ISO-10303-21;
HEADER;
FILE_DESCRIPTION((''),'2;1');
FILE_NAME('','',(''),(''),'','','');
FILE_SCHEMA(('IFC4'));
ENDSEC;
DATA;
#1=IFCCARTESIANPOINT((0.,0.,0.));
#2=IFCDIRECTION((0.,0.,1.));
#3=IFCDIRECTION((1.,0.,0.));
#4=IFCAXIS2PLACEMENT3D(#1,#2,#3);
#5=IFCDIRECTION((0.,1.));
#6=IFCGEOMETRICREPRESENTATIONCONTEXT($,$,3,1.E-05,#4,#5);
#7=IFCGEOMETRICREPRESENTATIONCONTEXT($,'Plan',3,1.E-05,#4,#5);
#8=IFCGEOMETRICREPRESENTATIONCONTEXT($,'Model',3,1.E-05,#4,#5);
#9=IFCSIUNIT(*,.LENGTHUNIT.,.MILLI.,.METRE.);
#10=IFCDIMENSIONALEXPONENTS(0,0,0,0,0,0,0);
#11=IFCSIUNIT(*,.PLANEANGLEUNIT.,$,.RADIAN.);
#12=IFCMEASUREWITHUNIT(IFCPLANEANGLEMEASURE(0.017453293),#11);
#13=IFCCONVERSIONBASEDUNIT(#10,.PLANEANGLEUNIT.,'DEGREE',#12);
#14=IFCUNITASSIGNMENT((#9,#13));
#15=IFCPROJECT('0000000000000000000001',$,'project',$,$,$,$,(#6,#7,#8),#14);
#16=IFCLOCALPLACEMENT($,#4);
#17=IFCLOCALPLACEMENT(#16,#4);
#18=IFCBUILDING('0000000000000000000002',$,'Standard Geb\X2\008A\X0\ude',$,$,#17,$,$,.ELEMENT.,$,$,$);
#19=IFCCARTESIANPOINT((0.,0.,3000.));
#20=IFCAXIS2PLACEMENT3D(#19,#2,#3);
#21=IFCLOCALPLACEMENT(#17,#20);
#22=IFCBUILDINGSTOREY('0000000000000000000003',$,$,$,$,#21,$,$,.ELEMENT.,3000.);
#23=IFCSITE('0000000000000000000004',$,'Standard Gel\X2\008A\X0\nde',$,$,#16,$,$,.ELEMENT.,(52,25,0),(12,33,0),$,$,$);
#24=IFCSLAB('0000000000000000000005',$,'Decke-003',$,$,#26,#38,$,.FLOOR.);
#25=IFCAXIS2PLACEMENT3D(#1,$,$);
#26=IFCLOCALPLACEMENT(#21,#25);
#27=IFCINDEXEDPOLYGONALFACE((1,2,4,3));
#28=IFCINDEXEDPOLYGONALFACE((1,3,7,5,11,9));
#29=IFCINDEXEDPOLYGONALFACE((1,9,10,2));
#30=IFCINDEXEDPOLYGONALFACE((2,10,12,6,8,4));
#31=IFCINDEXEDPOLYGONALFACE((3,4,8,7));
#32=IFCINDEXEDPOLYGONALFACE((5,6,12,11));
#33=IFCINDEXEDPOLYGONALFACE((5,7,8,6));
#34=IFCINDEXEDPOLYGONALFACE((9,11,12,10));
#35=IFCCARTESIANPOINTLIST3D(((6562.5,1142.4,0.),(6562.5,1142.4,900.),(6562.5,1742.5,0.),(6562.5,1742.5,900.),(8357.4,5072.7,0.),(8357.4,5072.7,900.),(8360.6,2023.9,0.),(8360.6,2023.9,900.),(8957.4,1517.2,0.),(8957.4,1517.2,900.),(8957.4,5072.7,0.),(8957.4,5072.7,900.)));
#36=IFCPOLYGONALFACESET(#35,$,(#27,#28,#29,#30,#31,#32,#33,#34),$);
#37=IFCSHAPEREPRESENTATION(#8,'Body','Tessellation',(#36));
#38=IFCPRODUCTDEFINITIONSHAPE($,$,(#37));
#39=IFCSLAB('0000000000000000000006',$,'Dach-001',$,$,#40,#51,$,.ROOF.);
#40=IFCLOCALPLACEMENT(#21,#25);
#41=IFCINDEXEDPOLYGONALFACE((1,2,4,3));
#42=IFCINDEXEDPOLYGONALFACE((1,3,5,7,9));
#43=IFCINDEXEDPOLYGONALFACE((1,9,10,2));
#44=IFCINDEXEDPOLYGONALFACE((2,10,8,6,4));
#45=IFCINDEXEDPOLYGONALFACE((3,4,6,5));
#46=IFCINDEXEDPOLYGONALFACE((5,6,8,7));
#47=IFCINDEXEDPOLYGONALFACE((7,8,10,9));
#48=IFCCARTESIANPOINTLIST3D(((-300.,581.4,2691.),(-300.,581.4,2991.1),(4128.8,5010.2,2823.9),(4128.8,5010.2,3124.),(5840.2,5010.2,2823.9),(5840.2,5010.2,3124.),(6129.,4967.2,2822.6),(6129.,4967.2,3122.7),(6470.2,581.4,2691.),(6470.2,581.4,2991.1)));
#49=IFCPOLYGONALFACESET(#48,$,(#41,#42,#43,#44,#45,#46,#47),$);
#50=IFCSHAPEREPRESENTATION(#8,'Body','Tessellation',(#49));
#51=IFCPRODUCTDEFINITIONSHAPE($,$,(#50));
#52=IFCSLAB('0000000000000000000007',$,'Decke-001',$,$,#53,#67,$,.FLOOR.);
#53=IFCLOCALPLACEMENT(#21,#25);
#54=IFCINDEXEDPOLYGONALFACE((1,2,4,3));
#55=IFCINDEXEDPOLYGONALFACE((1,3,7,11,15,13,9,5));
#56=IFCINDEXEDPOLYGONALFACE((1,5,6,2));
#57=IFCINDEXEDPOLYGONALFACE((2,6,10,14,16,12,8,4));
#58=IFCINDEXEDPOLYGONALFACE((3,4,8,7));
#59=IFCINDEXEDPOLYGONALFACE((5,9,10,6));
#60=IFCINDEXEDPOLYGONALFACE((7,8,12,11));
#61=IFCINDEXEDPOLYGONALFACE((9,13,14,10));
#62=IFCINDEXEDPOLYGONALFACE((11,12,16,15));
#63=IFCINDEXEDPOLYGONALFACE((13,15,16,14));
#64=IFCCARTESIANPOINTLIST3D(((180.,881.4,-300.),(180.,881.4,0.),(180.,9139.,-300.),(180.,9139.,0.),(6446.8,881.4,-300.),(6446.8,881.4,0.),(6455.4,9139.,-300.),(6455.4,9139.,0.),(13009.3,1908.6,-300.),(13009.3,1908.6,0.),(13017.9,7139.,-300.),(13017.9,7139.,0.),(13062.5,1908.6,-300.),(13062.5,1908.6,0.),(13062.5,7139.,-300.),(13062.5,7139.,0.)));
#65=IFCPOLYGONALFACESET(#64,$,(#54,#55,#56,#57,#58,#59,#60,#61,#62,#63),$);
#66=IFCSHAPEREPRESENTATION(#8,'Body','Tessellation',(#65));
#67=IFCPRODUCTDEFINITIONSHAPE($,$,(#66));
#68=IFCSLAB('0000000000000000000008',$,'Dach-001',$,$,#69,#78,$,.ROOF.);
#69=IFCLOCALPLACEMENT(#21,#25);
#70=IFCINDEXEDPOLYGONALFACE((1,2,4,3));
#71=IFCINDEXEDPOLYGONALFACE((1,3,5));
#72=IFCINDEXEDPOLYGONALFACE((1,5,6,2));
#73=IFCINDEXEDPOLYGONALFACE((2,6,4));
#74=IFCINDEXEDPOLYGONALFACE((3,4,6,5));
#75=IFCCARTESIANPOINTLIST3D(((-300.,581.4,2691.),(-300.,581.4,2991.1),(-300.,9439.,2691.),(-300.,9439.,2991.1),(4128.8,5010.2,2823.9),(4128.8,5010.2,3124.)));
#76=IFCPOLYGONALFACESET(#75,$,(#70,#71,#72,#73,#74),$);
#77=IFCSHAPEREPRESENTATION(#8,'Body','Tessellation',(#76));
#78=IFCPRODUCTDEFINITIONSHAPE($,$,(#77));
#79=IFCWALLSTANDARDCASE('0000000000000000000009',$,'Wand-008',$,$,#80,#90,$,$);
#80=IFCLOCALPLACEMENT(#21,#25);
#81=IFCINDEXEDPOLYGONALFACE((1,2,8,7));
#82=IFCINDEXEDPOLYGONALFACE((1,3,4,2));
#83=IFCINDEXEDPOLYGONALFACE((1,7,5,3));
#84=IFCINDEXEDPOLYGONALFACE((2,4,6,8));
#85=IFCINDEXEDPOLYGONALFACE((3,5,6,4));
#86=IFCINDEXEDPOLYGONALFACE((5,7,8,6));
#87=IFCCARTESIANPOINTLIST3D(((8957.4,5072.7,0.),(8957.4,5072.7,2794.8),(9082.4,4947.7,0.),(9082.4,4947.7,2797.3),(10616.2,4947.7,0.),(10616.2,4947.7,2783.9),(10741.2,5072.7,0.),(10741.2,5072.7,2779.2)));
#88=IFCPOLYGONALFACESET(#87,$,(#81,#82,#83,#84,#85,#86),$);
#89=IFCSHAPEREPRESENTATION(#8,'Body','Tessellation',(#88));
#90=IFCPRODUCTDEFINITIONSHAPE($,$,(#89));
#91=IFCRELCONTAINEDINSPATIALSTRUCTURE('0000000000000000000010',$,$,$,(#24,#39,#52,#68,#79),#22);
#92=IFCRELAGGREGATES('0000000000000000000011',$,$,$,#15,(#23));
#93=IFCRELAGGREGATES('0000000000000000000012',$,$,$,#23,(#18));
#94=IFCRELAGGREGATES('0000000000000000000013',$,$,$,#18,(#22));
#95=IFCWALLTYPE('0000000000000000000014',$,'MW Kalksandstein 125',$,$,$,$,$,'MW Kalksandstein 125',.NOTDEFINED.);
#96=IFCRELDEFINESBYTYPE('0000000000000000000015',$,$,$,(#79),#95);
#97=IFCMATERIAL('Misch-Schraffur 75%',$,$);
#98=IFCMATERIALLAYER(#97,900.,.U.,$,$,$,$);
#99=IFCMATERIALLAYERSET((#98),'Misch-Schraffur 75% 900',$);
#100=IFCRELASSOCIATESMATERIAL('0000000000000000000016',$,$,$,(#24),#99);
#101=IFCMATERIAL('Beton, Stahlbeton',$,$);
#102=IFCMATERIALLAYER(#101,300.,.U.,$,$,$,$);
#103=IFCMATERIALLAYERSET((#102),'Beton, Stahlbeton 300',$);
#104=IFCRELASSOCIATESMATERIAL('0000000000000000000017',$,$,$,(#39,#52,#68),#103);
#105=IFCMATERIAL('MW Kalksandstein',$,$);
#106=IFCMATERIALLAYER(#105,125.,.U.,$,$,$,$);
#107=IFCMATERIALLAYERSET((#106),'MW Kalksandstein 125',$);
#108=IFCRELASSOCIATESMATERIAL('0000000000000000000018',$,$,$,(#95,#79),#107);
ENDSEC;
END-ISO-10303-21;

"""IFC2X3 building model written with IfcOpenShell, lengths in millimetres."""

from ifc_helpers import new_model, entity, si_unit, converted_unit, direction, frame, origin_with_axes, place, context, project, spatial, polyline, outline, extrude, clip, halfspace, material, layer, layer_set, layer_usage, type_object, element, save


model = new_model("IFC2X3")

# Units and contexts
model_context = context("Model", 3, precision=1e-05, world=origin_with_axes(), true_north=direction((0.0, 1.0)))
context_of_model = context(None, 3, precision=1e-05, world=origin_with_axes(), true_north=direction((0.0, 1.0)))
plan_context = context("Plan", 3, precision=1e-05, world=origin_with_axes(), true_north=direction((0.0, 1.0)))
ifc_project = project(units=[si_unit("LENGTHUNIT", "METRE", prefix="MILLI"), converted_unit("PLANEANGLEUNIT", "DEGREE", entity("IfcPlaneAngleMeasure", 0.017453293), si_unit("PLANEANGLEUNIT", "RADIAN"), dimensions=[0, 0, 0, 0, 0, 0, 0])], contexts=[context_of_model, plan_context, model_context])

# Site, building, storey
site_placement = place(None, origin_with_axes())
site = spatial("IfcSite", under=ifc_project, at=site_placement, Name="Standard Gel\u008ande", CompositionType="ELEMENT", RefLatitude=(52, 25, 0), RefLongitude=(12, 33, 0))
building_placement = place(site_placement, origin_with_axes())
building = spatial("IfcBuilding", under=site, at=building_placement, Name="Standard Geb\u008aude", CompositionType="ELEMENT")
storey_placement = place(building_placement, frame((0.0, 0.0, 3000.0), z_axis=(0.0, 0.0, 1.0), x_axis=(1.0, 0.0, 0.0)))
storey = spatial("IfcBuildingStorey", under=building, at=storey_placement, CompositionType="ELEMENT", Elevation=3000.0)

# Slabs
ifc_material_1 = material(Name="Misch-Schraffur 75%")
ifc_layer_1 = layer(ifc_material_1, 900.0, ventilated="UNKNOWN")
ifc_layer_set_1 = layer_set([ifc_layer_1], Name="Misch-Schraffur 75% 900")
ifc_layer_usage_1 = layer_usage(ifc_layer_set_1, "AXIS3", "NEGATIVE", 900.0)
slab_1_placement = place(storey_placement, frame((8360.6, 2023.9, 0.0), z_axis=(0.0, 0.0, 1.0), x_axis=(-0.98797, -0.154644, 0.0)))
element("IfcSlab", 1, at=slab_1_placement, inside=storey, material=ifc_layer_usage_1, Name="Decke-003", PredefinedType="FLOOR", context=model_context, shape_type="SweptSolid", body=[
    extrude(outline(polyline([(0.0, 0.0), (1820.0, 0.0), (1912.8, 592.9), (-511.3, 592.9), (-1061.1, -2919.8), (-468.3, -3012.6), (0.0, 0.0)])), origin_with_axes(), (0.0, 0.0, 1.0), 900.0),
])
ifc_material_2 = material(Name="Beton, Stahlbeton")
ifc_layer_2 = layer(ifc_material_2, 300.0, ventilated="UNKNOWN")
ifc_layer_set_2 = layer_set([ifc_layer_2], Name="Beton, Stahlbeton 300")
ifc_layer_usage_2 = layer_usage(ifc_layer_set_2, "AXIS3", "NEGATIVE", 300.0)
slab_2_placement = place(storey_placement, frame((0.0, 881.4, 2700.0), z_axis=(0.0, -0.029987, 0.99955), x_axis=(1.0, 0.0, 0.0)))
element("IfcSlab", 2, at=slab_2_placement, inside=storey, material=ifc_layer_usage_2, Name="Dach-001", PredefinedType="ROOF", context=model_context, shape_type="SweptSolid", body=[
    extrude(outline(polyline([(-300.0, -300.1), (6470.2, -300.1), (6129.0, 4087.6), (5840.2, 4130.7), (4128.8, 4130.7), (-300.0, -300.1)])), origin_with_axes(), (0.0, 0.029987, 0.99955), 300.1),
])
ifc_layer_usage_3 = layer_usage(ifc_layer_set_2, "AXIS3", "NEGATIVE", 300.0)
slab_3_placement = place(storey_placement, frame((180.0, 9139.0, -300.0), z_axis=(0.0, 0.0, 1.0), x_axis=(1.0, 0.0, 0.0)))
element("IfcSlab", 3, at=slab_3_placement, inside=storey, material=ifc_layer_usage_3, Name="Decke-001", PredefinedType="FLOOR", context=model_context, shape_type="SweptSolid", body=[
    extrude(outline(polyline([(0.0, 0.0), (6275.4, 0.0), (12837.9, -2000.0), (12882.5, -2000.0), (12882.5, -7230.5), (12829.3, -7230.5), (6266.8, -8257.7), (0.0, -8257.7), (0.0, 0.0)])), origin_with_axes(), (0.0, 0.0, 1.0), 300.0),
])
ifc_layer_usage_4 = layer_usage(ifc_layer_set_2, "AXIS3", "NEGATIVE", 300.0)
slab_4_placement = place(storey_placement, frame((0.0, 9139.0, 2700.0), z_axis=(-0.029987, 0.0, 0.99955), x_axis=(0.0, -1.0, 0.0)))
element("IfcSlab", 4, at=slab_4_placement, inside=storey, material=ifc_layer_usage_4, Name="Dach-001", PredefinedType="ROOF", context=model_context, shape_type="SweptSolid", body=[
    extrude(outline(polyline([(-300.0, -300.1), (8557.7, -300.1), (4128.8, 4130.7), (-300.0, -300.1)])), origin_with_axes(), (0.0, 0.029987, 0.99955), 300.1),
])

# Shared definitions
ifc_material_3 = material(Name="MW Kalksandstein")
ifc_layer_3 = layer(ifc_material_3, 125.0, ventilated="UNKNOWN")
ifc_layer_set_3 = layer_set([ifc_layer_3], Name="MW Kalksandstein 125")
wall_type = type_object("IfcWallType", Name="MW Kalksandstein 125", ElementType="MW Kalksandstein 125", PredefinedType="NOTDEFINED", material=ifc_layer_set_3)

# Wall
ifc_layer_usage_5 = layer_usage(ifc_layer_set_3, "AXIS2", "POSITIVE", -62.5)
wall_1_placement = place(storey_placement, frame((9019.9, 5010.2, 0.0), z_axis=(0.0, 0.0, 1.0), x_axis=(1.0, 0.0, 0.0)))
element("IfcWallStandardCase", 5, at=wall_1_placement, inside=storey, type_object=wall_type, material=ifc_layer_usage_5, Name="Wand-008", context=model_context, shape_type="Clipping", body=[
    clip(extrude(outline(polyline([(62.5, -62.5), (1596.3, -62.5), (1721.3, 62.5), (-62.5, 62.5), (62.5, -62.5)])), origin_with_axes(), (0.0, 0.0, 1.0), 3200.0), halfspace(frame((24.4, 80.2, 2793.5), z_axis=(0.008742, 0.028684, 0.99955), x_axis=(0.0, 0.999588, -0.028685)), False)),
])

save(model, "model.ifc")
